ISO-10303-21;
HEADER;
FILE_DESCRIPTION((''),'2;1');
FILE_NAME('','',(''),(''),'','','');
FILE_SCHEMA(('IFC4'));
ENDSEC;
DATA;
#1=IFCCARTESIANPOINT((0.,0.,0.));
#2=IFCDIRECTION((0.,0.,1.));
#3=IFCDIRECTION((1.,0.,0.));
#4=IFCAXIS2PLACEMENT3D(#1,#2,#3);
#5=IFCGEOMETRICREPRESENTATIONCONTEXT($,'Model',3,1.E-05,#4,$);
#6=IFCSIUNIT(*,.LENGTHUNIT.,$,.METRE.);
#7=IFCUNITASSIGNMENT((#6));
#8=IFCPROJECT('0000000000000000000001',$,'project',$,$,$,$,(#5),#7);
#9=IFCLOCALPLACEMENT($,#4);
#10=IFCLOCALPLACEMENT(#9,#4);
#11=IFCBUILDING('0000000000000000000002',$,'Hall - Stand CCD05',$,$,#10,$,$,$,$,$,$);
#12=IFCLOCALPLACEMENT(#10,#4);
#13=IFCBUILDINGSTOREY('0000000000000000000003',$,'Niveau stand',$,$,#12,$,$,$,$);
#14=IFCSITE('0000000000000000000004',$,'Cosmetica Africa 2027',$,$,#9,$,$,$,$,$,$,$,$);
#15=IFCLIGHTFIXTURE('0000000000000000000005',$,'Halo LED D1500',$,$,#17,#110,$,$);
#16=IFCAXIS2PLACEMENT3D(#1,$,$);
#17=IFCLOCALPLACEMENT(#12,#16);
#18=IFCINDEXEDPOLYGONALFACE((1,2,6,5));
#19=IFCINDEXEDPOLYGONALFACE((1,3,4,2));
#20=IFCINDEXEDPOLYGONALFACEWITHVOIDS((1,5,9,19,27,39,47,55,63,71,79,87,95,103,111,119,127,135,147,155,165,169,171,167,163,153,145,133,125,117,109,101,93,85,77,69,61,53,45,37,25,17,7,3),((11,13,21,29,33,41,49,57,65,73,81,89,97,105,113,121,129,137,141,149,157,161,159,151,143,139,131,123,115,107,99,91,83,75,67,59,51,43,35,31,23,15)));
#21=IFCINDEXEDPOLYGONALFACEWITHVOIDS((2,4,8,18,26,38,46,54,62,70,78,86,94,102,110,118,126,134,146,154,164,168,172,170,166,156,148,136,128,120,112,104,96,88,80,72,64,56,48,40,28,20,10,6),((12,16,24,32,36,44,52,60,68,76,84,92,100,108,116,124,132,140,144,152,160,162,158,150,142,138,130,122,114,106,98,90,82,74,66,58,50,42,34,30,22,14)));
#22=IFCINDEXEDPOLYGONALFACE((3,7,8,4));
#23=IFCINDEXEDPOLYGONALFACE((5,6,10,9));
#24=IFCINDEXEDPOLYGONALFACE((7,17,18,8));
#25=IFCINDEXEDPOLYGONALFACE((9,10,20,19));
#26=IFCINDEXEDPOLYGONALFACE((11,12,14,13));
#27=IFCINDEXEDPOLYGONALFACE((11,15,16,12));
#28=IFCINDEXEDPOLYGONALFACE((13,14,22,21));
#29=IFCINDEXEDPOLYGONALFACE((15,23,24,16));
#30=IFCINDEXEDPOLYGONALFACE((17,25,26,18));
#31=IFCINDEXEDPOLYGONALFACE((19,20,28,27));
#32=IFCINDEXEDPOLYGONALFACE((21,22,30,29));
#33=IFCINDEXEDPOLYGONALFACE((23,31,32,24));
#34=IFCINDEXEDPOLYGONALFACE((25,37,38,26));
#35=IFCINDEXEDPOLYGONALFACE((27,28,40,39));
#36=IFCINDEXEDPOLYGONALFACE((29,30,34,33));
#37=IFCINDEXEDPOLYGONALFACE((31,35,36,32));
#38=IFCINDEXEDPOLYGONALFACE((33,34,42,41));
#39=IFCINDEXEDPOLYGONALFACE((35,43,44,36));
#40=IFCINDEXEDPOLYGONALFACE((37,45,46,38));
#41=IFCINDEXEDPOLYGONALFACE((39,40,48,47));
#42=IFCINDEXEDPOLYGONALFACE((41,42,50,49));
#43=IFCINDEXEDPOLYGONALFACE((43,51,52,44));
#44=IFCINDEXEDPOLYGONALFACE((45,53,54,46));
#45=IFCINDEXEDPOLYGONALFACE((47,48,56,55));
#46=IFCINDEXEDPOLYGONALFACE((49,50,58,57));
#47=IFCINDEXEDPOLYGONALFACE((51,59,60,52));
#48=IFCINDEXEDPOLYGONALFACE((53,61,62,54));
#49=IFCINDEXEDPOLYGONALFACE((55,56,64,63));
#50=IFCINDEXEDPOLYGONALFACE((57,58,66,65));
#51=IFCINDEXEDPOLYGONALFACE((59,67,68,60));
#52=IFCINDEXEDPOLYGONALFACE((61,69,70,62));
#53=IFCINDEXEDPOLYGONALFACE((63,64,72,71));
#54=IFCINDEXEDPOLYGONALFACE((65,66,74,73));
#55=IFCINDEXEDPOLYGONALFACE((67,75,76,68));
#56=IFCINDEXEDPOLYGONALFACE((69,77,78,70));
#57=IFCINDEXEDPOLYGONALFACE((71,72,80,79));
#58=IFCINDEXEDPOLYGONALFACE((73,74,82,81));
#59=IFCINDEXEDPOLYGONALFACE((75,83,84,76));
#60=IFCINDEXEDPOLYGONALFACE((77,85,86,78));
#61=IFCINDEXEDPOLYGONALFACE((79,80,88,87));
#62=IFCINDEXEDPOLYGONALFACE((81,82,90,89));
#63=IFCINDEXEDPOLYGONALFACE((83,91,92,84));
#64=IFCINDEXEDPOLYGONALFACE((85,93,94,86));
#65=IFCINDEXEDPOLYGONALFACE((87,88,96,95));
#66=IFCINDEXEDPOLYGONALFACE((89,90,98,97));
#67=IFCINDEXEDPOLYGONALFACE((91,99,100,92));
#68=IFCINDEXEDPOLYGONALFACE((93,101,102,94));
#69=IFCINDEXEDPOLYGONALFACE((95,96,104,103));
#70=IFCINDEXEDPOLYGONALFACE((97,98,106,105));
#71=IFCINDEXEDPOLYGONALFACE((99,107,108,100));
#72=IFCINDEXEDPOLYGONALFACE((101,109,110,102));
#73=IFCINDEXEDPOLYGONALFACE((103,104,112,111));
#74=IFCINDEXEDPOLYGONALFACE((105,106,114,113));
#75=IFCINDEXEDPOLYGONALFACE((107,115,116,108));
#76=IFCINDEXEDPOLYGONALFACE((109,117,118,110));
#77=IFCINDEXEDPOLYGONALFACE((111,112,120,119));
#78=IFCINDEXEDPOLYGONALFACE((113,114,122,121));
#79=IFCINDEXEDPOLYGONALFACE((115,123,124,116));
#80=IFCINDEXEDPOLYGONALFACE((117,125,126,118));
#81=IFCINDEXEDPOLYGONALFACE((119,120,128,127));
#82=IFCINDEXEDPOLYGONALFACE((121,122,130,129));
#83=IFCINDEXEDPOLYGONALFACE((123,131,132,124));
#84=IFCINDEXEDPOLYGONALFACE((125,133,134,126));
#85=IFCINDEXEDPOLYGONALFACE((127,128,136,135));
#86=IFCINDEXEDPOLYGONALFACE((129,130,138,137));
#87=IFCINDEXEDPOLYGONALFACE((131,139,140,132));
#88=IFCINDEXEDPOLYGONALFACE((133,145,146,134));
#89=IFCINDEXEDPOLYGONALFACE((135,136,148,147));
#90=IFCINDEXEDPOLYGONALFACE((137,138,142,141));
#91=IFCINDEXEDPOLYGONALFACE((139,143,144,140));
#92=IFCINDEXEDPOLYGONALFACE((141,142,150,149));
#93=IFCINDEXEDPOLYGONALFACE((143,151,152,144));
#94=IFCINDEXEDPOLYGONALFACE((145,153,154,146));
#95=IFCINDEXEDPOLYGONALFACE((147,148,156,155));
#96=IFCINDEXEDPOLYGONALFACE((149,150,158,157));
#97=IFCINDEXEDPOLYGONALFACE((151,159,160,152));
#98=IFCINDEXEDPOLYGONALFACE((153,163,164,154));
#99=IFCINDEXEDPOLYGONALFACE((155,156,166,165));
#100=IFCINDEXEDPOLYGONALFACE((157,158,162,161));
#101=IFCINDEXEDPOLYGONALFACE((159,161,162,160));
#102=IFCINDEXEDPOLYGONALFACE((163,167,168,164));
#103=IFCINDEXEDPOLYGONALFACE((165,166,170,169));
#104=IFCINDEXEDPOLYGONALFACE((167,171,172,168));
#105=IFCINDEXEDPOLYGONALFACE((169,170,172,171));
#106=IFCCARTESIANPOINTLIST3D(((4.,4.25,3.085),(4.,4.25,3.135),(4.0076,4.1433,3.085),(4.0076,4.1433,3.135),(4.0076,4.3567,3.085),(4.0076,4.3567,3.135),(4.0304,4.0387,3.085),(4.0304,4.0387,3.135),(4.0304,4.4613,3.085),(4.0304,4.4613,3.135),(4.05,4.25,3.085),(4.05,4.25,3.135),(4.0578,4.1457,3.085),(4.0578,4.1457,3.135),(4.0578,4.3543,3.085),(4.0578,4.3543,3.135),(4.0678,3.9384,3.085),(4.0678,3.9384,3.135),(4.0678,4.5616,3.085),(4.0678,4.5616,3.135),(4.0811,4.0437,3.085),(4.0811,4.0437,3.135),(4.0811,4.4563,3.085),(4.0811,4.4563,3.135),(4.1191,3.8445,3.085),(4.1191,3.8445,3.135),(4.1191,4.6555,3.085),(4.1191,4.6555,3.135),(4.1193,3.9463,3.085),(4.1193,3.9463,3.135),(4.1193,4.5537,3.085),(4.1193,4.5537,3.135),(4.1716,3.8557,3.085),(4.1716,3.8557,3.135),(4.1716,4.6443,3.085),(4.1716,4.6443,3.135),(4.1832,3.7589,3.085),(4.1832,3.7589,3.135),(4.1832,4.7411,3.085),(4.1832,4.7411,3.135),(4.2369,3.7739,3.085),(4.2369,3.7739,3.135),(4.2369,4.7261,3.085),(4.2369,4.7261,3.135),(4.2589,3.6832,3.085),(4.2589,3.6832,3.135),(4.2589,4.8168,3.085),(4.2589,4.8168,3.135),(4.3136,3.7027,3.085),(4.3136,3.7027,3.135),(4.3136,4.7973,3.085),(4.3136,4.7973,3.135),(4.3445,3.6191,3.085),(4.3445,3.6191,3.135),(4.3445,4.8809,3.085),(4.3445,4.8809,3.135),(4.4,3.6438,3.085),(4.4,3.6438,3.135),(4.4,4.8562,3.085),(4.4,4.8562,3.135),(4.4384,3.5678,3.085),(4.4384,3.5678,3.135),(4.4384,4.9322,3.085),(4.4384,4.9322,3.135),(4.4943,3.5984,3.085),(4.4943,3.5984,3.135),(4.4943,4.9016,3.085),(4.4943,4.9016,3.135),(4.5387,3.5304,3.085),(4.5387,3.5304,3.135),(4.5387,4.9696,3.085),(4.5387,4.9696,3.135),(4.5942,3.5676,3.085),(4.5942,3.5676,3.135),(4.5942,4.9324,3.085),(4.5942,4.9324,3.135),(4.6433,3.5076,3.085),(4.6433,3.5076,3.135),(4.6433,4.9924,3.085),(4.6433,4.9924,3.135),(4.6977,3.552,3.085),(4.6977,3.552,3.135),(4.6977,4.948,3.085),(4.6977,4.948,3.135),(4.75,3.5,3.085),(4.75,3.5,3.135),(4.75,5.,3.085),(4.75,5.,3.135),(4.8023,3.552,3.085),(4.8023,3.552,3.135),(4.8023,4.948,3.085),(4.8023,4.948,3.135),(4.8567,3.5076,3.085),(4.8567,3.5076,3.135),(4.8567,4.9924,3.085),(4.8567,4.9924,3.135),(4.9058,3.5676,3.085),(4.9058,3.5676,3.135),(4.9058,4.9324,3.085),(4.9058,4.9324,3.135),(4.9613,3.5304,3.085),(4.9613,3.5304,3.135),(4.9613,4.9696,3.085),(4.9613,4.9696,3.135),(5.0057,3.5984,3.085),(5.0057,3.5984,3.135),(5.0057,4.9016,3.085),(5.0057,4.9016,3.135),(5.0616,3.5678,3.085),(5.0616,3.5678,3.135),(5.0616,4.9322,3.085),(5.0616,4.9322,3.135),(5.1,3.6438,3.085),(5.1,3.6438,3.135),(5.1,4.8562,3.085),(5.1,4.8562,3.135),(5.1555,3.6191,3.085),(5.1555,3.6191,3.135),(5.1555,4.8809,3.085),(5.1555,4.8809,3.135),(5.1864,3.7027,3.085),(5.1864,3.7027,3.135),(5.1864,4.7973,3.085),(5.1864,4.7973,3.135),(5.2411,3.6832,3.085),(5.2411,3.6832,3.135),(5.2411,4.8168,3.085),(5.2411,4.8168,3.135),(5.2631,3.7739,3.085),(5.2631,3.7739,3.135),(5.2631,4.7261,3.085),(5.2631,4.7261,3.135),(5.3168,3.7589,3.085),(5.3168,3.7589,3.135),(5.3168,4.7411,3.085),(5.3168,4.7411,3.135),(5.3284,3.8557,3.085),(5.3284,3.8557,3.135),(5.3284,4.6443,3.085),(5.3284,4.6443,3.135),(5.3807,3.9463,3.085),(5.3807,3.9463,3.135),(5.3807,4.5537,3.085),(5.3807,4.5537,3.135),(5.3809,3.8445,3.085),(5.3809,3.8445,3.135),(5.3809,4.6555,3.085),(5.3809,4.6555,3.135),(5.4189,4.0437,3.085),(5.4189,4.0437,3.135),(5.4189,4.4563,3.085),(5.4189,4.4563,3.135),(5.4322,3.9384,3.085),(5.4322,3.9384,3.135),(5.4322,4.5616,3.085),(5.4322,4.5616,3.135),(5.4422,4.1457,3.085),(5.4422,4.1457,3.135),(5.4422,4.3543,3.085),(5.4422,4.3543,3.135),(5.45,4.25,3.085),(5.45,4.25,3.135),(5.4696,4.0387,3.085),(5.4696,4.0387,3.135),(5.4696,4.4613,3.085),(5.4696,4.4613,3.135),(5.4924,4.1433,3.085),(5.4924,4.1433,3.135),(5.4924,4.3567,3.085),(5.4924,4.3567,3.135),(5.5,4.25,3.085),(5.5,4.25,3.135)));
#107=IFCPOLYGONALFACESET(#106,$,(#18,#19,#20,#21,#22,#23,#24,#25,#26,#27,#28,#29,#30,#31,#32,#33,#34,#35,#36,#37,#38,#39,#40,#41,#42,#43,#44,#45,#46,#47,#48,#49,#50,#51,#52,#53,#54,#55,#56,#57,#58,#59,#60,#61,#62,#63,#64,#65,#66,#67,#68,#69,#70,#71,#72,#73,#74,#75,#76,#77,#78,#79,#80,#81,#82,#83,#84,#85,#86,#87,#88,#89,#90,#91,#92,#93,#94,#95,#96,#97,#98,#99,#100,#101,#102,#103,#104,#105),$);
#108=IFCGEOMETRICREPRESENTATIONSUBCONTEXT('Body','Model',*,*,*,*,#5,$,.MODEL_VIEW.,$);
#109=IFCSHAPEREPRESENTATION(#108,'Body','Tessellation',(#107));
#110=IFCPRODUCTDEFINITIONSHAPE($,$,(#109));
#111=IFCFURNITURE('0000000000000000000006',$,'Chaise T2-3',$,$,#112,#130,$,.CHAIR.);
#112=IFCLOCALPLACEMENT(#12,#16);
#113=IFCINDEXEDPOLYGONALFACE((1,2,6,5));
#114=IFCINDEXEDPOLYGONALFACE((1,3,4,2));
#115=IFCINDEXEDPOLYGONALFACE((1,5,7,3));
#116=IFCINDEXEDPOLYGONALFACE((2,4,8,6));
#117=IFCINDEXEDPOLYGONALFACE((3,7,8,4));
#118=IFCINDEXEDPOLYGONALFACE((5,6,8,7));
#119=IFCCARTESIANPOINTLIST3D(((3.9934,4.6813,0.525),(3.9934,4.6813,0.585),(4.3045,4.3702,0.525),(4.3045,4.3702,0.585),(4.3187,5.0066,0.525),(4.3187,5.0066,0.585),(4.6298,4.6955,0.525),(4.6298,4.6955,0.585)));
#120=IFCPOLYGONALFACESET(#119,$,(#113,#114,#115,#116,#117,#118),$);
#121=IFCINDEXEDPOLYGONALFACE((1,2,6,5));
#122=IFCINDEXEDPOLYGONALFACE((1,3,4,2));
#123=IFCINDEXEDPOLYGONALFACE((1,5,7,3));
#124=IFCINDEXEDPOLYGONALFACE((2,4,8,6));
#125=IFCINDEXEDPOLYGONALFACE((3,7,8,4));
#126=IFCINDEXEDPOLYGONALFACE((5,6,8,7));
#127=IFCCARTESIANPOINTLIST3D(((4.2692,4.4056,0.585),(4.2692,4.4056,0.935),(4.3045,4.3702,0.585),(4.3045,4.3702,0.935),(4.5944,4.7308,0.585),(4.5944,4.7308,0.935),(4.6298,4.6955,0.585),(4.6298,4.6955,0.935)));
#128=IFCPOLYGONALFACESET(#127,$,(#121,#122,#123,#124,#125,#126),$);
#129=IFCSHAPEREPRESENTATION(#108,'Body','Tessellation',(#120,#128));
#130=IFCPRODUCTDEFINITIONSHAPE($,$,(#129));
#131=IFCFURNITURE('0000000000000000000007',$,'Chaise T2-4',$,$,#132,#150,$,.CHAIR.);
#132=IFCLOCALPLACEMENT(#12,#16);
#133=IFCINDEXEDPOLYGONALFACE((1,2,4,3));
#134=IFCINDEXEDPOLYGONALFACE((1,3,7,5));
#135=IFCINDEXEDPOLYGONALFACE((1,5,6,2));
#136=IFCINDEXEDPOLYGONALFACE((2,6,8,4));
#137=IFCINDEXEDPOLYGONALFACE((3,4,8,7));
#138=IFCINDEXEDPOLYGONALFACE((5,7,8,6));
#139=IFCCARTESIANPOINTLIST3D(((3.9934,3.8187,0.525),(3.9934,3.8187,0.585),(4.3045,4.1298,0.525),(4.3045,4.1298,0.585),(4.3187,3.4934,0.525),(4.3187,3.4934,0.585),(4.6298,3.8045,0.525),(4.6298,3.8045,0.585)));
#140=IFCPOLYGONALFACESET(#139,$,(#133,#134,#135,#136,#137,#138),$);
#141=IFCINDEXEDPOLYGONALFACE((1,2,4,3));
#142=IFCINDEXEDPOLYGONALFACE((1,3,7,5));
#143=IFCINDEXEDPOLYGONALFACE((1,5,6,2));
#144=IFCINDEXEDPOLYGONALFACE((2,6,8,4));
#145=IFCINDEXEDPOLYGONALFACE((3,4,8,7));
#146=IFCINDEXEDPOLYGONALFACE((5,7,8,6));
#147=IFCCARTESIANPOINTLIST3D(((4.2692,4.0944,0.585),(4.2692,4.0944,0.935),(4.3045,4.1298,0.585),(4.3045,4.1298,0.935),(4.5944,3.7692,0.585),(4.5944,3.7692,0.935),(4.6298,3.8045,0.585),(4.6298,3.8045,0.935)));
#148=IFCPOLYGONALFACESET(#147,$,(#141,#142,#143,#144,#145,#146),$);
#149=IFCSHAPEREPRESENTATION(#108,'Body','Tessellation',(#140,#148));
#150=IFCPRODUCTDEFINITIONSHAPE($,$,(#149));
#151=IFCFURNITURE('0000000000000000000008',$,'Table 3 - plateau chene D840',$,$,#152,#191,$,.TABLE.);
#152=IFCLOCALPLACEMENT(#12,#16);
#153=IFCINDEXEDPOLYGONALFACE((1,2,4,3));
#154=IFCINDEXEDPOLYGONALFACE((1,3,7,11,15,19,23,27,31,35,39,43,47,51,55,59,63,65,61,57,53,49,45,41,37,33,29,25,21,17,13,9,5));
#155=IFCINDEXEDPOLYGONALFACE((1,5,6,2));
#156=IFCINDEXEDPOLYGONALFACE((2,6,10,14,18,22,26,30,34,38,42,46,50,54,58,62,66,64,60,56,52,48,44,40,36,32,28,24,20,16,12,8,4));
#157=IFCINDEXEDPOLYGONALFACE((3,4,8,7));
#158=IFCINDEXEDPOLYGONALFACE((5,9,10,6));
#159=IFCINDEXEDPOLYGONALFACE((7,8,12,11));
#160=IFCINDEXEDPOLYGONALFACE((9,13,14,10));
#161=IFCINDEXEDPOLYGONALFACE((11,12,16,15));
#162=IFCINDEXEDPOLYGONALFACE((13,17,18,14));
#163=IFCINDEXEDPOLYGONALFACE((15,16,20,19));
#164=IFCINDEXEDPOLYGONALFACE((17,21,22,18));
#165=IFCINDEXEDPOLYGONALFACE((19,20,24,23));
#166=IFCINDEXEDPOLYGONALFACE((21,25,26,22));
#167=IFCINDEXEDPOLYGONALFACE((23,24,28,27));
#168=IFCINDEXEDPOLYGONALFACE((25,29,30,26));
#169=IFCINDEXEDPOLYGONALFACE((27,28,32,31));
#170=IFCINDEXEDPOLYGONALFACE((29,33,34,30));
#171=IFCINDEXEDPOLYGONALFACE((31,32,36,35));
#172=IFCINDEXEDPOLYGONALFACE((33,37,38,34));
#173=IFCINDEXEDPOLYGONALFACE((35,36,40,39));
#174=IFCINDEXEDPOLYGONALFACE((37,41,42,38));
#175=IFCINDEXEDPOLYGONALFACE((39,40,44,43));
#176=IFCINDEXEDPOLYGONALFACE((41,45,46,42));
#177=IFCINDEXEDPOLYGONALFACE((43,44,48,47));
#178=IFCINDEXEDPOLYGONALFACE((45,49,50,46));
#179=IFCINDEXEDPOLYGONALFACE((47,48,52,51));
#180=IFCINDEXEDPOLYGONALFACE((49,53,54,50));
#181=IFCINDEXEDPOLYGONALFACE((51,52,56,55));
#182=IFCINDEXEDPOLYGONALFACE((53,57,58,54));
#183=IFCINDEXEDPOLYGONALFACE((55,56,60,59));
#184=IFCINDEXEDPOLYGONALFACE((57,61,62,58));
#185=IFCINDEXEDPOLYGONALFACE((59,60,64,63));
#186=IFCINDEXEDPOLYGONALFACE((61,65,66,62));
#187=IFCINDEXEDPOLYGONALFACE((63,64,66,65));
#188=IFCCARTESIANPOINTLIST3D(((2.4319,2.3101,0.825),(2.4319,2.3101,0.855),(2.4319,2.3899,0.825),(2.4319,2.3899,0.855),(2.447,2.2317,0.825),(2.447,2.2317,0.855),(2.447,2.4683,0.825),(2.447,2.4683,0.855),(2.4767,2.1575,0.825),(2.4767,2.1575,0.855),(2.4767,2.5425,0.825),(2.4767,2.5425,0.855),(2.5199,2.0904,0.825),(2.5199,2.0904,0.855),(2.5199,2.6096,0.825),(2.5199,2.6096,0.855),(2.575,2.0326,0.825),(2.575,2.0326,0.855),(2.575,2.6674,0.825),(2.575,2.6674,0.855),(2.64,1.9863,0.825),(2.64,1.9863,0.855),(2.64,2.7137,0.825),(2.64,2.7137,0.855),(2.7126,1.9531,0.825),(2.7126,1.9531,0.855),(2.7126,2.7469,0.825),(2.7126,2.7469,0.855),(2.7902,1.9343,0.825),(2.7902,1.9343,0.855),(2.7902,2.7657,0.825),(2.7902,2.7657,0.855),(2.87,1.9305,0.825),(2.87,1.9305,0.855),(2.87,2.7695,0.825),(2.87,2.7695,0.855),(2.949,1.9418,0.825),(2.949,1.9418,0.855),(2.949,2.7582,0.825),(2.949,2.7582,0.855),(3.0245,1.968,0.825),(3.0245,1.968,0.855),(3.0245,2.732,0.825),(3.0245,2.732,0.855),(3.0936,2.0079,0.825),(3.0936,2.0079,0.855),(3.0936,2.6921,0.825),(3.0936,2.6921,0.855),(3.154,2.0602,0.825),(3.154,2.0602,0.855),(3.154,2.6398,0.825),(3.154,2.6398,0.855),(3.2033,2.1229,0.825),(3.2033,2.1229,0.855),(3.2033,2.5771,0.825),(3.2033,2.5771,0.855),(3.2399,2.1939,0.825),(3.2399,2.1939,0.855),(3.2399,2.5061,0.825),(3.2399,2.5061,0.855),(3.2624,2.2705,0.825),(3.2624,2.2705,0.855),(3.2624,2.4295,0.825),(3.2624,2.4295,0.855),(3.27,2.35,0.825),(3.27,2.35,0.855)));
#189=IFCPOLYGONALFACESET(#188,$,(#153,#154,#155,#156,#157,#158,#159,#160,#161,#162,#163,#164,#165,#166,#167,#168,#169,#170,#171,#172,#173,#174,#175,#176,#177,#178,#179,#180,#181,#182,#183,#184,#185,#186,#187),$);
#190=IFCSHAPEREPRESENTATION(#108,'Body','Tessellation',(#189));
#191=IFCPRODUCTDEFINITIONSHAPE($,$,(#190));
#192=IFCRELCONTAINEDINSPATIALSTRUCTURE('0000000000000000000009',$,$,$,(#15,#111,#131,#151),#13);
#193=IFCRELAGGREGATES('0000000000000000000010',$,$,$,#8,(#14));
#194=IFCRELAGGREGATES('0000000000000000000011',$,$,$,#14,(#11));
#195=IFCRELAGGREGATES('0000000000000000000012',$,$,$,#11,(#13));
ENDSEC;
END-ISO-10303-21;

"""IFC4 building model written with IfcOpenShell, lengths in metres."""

from ifc_helpers import new_model, si_unit, frame, frame_2d, origin_with_axes, place, context, subcontext, project, spatial, polyline, circle, hollow_circle, outline, extrude, element, save


model = new_model("IFC4")

# Units and contexts
model_context = context("Model", 3, precision=1e-05, world=origin_with_axes())
body_context = subcontext(model_context, "Body", "Model", "MODEL_VIEW")
ifc_project = project(units=[si_unit("LENGTHUNIT", "METRE")], contexts=[model_context])

# Site, building, storey
site_placement = place(None, origin_with_axes())
site = spatial("IfcSite", under=ifc_project, at=site_placement, Name="Cosmetica Africa 2027")
building_placement = place(site_placement, origin_with_axes())
building = spatial("IfcBuilding", under=site, at=building_placement, Name="Hall - Stand CCD05")
storey_placement = place(building_placement, origin_with_axes())
storey = spatial("IfcBuildingStorey", under=building, at=storey_placement, Name="Niveau stand")

# Light fixture
light_fixture_1_placement = place(storey_placement, origin_with_axes())
element("IfcLightFixture", 1, at=light_fixture_1_placement, inside=storey, Name="Halo LED D1500", context=body_context, shape_type="SweptSolid", body=[
    extrude(hollow_circle(Radius=0.75, WallThickness=0.05, at=frame_2d((4.75, 4.25))), frame((0.0, 0.0, 3.085)), (0.0, 0.0, 1.0), 0.05),
])

# Furniture
furniture_1_placement = place(storey_placement, origin_with_axes())
element("IfcFurniture", 2, at=furniture_1_placement, inside=storey, Name="Chaise T2-3", PredefinedType="CHAIR", context=body_context, shape_type="SweptSolid", body=[
    extrude(outline(polyline([(4.3187, 5.0066), (3.9934, 4.6813), (4.3045, 4.3702), (4.6298, 4.6955), (4.3187, 5.0066)])), frame((0.0, 0.0, 0.525)), (0.0, 0.0, 1.0), 0.06),
    extrude(outline(polyline([(4.5944, 4.7308), (4.2692, 4.4056), (4.3045, 4.3702), (4.6298, 4.6955), (4.5944, 4.7308)])), frame((0.0, 0.0, 0.585)), (0.0, 0.0, 1.0), 0.35),
])
furniture_2_placement = place(storey_placement, origin_with_axes())
element("IfcFurniture", 3, at=furniture_2_placement, inside=storey, Name="Chaise T2-4", PredefinedType="CHAIR", context=body_context, shape_type="SweptSolid", body=[
    extrude(outline(polyline([(3.9934, 3.8187), (4.3187, 3.4934), (4.6298, 3.8045), (4.3045, 4.1298), (3.9934, 3.8187)])), frame((0.0, 0.0, 0.525)), (0.0, 0.0, 1.0), 0.06),
    extrude(outline(polyline([(4.2692, 4.0944), (4.5944, 3.7692), (4.6298, 3.8045), (4.3045, 4.1298), (4.2692, 4.0944)])), frame((0.0, 0.0, 0.585)), (0.0, 0.0, 1.0), 0.35),
])
furniture_3_placement = place(storey_placement, origin_with_axes())
element("IfcFurniture", 4, at=furniture_3_placement, inside=storey, Name="Table 3 - plateau chene D840", PredefinedType="TABLE", context=body_context, shape_type="SweptSolid", body=[
    extrude(circle(Radius=0.42, at=frame_2d((2.85, 2.35))), frame((0.0, 0.0, 0.825)), (0.0, 0.0, 1.0), 0.03),
])

save(model, "model.ifc")
